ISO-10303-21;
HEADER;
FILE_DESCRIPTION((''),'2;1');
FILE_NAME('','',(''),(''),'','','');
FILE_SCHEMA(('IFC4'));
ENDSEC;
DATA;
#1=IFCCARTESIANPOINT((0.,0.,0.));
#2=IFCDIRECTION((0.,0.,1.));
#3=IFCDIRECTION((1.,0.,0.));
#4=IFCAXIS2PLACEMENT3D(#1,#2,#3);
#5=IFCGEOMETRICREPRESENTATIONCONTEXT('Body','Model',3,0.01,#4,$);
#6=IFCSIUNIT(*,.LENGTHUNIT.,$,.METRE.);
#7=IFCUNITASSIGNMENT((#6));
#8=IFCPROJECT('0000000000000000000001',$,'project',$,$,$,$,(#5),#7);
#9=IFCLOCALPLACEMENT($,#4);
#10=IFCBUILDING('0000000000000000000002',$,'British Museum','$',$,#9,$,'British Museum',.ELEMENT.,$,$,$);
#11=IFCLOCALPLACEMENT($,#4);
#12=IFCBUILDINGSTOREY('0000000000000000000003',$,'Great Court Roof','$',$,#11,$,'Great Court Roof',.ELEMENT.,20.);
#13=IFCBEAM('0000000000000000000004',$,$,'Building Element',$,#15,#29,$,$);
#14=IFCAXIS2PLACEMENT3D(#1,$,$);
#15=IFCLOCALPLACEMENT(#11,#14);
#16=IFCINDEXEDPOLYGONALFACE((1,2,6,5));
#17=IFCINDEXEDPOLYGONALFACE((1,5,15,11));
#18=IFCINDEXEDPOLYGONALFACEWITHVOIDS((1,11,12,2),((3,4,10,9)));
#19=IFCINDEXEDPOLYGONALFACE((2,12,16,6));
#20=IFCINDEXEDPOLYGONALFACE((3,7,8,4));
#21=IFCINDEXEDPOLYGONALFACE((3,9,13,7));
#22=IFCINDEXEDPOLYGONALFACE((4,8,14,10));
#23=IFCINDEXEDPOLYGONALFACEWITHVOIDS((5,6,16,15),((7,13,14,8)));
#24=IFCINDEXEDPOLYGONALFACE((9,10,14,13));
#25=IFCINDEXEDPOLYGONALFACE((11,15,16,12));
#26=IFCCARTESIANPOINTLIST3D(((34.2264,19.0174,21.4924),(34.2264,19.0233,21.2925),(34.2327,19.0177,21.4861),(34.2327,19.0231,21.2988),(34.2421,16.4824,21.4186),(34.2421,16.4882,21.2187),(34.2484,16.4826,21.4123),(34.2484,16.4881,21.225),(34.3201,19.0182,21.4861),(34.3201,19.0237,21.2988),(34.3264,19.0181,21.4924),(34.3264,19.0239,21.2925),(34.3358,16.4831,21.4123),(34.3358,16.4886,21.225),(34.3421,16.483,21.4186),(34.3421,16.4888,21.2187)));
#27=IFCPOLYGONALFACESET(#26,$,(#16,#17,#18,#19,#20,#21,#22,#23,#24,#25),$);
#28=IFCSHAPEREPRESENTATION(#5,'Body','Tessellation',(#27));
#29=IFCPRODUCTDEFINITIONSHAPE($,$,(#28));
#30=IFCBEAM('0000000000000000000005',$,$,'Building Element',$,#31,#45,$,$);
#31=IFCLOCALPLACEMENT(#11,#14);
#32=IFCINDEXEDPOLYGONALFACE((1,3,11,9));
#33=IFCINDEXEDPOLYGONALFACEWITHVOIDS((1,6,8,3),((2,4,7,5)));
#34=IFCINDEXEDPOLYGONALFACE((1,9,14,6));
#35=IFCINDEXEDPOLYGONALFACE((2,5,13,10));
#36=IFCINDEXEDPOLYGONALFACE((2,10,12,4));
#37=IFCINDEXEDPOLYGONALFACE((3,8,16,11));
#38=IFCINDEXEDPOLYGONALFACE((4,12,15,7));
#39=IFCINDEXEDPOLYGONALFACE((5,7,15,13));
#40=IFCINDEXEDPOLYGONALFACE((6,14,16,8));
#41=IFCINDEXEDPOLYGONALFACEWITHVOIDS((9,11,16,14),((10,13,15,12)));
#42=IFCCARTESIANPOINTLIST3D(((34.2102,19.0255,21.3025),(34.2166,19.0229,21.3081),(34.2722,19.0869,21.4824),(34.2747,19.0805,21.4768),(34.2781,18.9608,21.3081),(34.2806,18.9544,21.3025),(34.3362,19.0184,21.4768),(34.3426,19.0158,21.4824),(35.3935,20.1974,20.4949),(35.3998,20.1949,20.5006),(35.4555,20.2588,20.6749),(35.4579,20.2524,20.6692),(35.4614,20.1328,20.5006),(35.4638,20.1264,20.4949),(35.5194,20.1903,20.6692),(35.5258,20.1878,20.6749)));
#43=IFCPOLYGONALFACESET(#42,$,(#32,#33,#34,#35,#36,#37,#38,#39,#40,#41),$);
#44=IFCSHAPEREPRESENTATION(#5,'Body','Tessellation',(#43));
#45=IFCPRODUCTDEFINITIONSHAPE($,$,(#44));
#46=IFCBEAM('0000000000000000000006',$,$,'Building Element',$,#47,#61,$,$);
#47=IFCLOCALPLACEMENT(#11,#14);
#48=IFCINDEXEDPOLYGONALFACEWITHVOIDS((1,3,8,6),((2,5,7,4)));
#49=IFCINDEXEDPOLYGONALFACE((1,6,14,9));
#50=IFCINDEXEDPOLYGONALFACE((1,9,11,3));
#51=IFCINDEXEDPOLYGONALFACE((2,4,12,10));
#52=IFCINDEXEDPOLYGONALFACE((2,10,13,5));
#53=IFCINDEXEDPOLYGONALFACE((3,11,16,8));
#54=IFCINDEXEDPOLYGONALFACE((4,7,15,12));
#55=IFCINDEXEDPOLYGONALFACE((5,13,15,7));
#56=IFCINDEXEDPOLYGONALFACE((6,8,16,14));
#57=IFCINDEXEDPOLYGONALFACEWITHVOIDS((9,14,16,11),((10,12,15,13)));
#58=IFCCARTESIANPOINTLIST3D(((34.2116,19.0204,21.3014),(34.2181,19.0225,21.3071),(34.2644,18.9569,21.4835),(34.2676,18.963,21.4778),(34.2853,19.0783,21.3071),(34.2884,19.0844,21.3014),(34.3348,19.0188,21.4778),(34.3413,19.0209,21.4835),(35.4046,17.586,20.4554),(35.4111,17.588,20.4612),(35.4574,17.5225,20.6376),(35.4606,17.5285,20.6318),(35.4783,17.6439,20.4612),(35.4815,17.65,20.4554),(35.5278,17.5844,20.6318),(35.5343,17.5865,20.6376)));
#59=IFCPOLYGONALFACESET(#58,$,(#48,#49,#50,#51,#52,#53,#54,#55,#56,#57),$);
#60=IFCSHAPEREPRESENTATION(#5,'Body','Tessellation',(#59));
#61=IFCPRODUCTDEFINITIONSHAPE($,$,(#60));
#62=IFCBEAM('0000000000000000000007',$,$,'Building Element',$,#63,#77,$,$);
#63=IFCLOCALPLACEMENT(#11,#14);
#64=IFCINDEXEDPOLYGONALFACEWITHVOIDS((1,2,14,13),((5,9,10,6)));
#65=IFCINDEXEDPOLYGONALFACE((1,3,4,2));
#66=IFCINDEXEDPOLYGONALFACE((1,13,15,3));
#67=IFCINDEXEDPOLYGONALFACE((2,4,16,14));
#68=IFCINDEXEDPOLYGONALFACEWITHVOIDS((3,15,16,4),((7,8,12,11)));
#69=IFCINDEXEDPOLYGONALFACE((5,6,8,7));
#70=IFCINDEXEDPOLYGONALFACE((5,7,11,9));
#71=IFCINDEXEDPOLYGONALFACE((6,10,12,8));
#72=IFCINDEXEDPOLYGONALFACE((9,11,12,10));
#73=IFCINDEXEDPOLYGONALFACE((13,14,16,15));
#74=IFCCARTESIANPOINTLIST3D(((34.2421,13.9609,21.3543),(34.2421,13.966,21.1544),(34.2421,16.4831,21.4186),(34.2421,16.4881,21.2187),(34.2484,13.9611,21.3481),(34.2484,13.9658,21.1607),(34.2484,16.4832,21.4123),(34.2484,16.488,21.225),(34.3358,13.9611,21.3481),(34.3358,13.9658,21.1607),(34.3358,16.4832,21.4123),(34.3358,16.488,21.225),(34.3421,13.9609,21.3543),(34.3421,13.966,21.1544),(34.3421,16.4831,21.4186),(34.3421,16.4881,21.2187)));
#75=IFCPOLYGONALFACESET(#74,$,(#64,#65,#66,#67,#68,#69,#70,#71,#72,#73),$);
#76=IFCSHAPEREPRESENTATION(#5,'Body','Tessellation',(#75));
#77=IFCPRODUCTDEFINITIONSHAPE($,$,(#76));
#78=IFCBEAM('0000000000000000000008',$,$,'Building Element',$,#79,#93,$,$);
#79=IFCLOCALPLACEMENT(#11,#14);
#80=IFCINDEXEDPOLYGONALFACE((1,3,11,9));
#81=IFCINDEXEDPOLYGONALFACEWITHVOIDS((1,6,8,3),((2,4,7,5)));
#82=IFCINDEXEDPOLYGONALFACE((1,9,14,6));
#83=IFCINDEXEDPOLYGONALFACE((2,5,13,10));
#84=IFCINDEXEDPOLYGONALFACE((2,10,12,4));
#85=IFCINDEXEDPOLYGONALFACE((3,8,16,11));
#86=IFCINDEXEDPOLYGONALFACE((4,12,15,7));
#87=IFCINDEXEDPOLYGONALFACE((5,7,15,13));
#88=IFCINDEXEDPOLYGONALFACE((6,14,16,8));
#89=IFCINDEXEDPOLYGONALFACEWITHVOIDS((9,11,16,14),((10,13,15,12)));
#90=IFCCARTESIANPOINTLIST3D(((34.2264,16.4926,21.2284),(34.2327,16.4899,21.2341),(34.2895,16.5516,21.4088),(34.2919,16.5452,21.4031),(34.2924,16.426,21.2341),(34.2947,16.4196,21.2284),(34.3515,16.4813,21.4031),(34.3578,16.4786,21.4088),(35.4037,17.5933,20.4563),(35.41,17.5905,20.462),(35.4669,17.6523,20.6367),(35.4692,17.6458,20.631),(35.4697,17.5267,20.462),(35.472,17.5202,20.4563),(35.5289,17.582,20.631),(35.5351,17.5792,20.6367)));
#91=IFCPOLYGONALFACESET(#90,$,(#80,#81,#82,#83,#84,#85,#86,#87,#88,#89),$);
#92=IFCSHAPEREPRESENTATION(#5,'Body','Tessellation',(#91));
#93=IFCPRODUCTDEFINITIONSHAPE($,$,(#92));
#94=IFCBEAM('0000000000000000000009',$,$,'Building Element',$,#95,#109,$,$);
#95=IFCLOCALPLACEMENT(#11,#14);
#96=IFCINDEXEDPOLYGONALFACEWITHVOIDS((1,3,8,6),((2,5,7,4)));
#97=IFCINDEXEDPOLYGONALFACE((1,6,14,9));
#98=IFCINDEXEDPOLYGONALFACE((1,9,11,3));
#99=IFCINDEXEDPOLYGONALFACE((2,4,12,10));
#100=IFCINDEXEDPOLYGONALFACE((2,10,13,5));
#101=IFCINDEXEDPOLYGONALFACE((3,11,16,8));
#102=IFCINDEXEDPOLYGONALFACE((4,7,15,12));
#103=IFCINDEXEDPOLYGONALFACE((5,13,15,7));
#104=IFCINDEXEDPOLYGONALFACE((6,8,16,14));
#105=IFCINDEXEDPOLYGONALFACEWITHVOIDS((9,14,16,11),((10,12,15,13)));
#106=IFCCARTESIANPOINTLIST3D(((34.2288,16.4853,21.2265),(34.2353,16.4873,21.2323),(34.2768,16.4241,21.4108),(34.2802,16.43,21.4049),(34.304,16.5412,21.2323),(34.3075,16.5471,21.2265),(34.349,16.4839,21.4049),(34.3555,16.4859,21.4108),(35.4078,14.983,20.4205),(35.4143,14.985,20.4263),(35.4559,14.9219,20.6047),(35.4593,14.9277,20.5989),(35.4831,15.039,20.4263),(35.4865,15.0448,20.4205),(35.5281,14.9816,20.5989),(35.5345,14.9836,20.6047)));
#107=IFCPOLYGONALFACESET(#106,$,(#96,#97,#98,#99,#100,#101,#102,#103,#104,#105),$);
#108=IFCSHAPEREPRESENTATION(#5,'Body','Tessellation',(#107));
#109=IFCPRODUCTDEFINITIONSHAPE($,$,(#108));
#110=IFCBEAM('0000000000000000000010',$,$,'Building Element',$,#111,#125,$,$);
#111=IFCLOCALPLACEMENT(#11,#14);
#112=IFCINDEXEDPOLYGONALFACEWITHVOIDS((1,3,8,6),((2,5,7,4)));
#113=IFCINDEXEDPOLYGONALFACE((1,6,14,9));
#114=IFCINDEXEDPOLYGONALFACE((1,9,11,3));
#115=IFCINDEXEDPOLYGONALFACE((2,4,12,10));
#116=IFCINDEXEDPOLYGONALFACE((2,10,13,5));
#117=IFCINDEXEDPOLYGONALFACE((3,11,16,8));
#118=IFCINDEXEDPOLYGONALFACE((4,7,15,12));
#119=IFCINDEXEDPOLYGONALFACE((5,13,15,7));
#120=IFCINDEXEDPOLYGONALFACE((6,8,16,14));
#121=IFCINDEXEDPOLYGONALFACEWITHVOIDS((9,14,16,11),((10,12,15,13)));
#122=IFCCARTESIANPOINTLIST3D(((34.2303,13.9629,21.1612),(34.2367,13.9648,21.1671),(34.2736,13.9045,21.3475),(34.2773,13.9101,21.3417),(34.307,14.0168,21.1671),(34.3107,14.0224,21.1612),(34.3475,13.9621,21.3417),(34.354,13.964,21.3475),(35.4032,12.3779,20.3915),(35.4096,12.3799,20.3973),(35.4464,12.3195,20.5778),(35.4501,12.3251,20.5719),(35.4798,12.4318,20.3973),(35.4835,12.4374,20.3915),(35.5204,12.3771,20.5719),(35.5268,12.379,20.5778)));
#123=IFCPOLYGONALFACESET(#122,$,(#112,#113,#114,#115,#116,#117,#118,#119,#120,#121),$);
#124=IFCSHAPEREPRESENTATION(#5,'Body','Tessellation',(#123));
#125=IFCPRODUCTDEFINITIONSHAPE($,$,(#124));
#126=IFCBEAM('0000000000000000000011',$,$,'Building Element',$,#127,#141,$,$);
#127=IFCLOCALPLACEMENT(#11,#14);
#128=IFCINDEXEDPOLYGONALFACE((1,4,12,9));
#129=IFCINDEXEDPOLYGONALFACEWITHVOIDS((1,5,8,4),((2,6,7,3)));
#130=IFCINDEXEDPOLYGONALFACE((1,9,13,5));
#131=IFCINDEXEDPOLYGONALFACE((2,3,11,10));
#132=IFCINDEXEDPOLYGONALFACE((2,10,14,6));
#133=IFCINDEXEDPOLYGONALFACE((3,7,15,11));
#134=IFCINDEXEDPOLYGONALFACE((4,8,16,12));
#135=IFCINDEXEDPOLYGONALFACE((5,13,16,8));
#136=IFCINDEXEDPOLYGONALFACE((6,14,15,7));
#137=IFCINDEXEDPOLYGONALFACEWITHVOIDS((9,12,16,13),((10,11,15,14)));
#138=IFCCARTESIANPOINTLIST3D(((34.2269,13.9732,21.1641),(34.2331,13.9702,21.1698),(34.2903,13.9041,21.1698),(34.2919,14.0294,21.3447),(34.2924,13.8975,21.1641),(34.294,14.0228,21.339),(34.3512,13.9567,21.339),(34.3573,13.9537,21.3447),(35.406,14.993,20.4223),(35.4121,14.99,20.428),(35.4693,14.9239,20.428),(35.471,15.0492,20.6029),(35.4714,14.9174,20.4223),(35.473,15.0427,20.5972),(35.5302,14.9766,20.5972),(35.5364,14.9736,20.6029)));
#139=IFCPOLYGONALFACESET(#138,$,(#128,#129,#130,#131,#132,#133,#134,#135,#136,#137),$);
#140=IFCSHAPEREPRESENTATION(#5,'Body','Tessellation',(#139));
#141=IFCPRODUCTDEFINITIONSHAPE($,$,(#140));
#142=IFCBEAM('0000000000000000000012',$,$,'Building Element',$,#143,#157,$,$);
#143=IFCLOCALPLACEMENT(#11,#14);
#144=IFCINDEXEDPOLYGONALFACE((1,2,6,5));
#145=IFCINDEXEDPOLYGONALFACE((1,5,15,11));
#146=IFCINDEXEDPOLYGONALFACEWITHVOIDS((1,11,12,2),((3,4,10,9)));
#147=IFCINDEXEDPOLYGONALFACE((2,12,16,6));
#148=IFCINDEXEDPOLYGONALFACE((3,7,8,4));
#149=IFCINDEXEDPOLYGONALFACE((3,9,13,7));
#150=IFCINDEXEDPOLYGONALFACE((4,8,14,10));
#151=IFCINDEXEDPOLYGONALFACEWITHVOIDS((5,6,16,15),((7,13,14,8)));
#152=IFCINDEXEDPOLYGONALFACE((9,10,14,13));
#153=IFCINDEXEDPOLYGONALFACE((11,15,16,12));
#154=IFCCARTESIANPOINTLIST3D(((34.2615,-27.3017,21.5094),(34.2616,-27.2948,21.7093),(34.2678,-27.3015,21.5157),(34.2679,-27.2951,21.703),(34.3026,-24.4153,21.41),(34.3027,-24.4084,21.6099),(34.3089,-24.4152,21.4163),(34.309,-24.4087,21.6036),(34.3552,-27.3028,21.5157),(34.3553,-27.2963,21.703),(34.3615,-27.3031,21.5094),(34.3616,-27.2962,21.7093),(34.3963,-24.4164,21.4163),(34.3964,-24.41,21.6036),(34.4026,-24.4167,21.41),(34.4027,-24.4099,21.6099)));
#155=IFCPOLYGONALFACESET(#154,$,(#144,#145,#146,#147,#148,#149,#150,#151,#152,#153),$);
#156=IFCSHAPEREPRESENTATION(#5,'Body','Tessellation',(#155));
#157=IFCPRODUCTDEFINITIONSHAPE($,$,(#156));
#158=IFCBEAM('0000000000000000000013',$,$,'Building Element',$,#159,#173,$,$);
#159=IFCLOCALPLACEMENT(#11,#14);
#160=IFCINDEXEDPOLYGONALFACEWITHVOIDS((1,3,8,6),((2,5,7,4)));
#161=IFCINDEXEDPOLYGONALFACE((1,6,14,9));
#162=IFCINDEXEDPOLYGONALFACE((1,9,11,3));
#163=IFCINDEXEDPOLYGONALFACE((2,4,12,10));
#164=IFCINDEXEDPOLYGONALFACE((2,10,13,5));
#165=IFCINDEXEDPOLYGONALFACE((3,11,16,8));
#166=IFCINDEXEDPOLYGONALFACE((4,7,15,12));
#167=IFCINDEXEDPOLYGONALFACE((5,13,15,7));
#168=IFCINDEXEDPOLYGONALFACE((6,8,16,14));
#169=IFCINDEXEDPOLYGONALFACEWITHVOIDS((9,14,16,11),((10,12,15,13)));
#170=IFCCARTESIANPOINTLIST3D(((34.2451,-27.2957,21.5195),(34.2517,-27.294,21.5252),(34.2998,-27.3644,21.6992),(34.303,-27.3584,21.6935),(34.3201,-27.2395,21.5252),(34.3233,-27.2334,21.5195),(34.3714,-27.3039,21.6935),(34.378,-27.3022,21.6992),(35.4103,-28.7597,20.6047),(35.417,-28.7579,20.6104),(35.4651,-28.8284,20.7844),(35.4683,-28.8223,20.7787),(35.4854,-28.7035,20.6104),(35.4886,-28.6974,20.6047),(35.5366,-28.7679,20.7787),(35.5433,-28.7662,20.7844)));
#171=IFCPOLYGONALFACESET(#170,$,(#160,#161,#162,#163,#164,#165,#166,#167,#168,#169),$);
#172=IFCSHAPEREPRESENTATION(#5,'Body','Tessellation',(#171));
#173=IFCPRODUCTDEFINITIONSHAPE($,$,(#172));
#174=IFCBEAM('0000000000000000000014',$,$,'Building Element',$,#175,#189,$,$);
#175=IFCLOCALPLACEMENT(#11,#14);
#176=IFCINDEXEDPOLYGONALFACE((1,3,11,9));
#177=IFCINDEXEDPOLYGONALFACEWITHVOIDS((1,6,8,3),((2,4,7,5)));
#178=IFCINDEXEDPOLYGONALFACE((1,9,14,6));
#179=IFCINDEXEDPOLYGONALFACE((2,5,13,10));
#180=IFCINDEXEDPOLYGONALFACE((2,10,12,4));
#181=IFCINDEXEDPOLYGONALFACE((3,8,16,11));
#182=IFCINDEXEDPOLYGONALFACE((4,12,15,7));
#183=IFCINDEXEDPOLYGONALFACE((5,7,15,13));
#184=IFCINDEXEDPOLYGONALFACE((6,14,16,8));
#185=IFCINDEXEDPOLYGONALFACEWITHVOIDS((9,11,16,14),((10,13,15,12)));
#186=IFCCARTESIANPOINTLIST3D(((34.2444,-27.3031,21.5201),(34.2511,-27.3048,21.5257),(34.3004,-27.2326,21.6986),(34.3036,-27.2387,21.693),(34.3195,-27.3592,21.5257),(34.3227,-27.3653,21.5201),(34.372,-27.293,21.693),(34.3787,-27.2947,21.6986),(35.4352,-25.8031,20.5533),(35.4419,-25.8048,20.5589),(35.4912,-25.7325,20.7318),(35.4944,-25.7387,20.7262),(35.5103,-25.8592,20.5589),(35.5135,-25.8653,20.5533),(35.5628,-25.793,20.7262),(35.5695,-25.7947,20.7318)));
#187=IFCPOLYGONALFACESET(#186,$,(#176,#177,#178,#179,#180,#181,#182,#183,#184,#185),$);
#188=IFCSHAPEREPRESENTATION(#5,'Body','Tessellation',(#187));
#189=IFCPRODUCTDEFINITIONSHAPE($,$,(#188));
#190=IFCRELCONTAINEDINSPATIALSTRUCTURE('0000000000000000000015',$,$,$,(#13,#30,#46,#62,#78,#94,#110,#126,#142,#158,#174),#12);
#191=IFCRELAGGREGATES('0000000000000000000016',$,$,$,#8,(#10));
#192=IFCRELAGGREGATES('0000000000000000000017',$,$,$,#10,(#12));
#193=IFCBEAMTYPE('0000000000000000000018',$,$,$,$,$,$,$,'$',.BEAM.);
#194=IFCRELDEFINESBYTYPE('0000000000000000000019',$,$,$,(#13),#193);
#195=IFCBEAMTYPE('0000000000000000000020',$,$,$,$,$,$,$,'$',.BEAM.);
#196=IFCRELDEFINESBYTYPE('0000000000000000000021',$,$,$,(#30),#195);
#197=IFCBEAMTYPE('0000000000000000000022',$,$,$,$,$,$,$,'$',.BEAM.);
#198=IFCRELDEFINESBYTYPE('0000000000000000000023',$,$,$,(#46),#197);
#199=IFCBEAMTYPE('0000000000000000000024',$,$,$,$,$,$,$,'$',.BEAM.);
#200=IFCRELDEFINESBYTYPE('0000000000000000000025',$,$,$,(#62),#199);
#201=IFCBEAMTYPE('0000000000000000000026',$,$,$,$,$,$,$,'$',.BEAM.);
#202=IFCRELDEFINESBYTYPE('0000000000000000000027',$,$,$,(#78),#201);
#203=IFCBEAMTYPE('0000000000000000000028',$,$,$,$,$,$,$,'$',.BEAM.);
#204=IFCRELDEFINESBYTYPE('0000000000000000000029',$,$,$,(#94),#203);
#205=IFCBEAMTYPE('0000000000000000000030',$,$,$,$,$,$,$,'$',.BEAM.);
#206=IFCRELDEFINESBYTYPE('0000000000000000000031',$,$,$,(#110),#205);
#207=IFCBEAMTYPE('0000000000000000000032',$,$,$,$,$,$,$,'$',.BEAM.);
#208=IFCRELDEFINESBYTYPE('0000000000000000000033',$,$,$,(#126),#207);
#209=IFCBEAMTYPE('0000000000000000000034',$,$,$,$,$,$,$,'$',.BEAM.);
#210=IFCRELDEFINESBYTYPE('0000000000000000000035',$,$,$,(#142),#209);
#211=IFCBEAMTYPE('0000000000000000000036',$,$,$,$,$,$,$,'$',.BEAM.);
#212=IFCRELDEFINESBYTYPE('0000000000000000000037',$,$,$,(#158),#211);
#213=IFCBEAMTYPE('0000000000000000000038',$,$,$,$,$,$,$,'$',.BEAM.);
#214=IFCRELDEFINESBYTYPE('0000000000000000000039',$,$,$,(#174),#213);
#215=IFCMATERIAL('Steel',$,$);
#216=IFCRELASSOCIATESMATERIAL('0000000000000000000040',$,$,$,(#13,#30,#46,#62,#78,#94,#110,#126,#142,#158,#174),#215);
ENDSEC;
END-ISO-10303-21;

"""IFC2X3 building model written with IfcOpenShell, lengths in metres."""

from ifc_helpers import new_model, si_unit, frame, origin_with_axes, origin_2d, place, context, project, spatial, hollow_rectangle, extrude, material, type_object, element, save


model = new_model("IFC2X3")

# Units and contexts
model_context = context("Model", 3, precision=0.01, world=origin_with_axes(), identifier="Body")
ifc_project = project(units=[si_unit("LENGTHUNIT", "METRE")], contexts=[model_context])

# Building, storey
building_placement = place(None, origin_with_axes())
building = spatial("IfcBuilding", under=ifc_project, at=building_placement, Name="British Museum", Description="$", LongName="British Museum", CompositionType="ELEMENT")
storey_placement = place(None, origin_with_axes())
storey = spatial("IfcBuildingStorey", under=building, at=storey_placement, Name="Great Court Roof", Description="$", LongName="Great Court Roof", CompositionType="ELEMENT", Elevation=20.0)

# Beams
ifc_material = material(Name="Steel")
beam_type_1 = type_object("IfcBeamType", ElementType="$", PredefinedType="BEAM")
beam_1_placement = place(None, origin_with_axes())
element("IfcBeam", 1, at=beam_1_placement, inside=storey, type_object=beam_type_1, material=ifc_material, Description="Building Element", context=model_context, shape_type="SweptSolid", body=[
    extrude(hollow_rectangle(XDim=0.1, YDim=0.2, WallThickness=0.0063, InnerFilletRadius=0.0, OuterFilletRadius=0.0, at=origin_2d()), frame((34.2764, 19.0207, 21.3924), z_axis=(0.006196, -0.999557, -0.029107), x_axis=(0.999981, 0.006198, 0.0)), (0.0, 0.0, 1.0), 2.5362),
])
beam_type_2 = type_object("IfcBeamType", ElementType="$", PredefinedType="BEAM")
beam_2_placement = place(None, origin_with_axes())
element("IfcBeam", 2, at=beam_2_placement, inside=storey, type_object=beam_type_2, material=ifc_material, Description="Building Element", context=model_context, shape_type="SweptSolid", body=[
    extrude(hollow_rectangle(XDim=0.1, YDim=0.2, WallThickness=0.0063, InnerFilletRadius=0.0, OuterFilletRadius=0.0, at=origin_2d()), frame((34.2764, 19.0207, 21.3924), z_axis=(0.639296, 0.633198, -0.436304), x_axis=(-0.70371, 0.710487, 0.0)), (0.0, 0.0, 1.0), 1.8508),
])
beam_type_3 = type_object("IfcBeamType", ElementType="$", PredefinedType="BEAM")
beam_3_placement = place(None, origin_with_axes())
element("IfcBeam", 3, at=beam_3_placement, inside=storey, type_object=beam_type_3, material=ifc_material, Description="Building Element", context=model_context, shape_type="SweptSolid", body=[
    extrude(hollow_rectangle(XDim=0.1, YDim=0.2, WallThickness=0.0063, InnerFilletRadius=0.0, OuterFilletRadius=0.0, at=origin_2d()), frame((34.2764, 19.0207, 21.3924), z_axis=(0.582379, -0.700216, -0.412956), x_axis=(0.768833, 0.639449, 0.0)), (0.0, 0.0, 1.0), 2.0485),
])
beam_type_4 = type_object("IfcBeamType", ElementType="$", PredefinedType="BEAM")
beam_4_placement = place(None, origin_with_axes())
element("IfcBeam", 4, at=beam_4_placement, inside=storey, type_object=beam_type_4, material=ifc_material, Description="Building Element", context=model_context, shape_type="SweptSolid", body=[
    extrude(hollow_rectangle(XDim=0.1, YDim=0.2, WallThickness=0.0063, InnerFilletRadius=0.0, OuterFilletRadius=0.0, at=origin_2d()), frame((34.2921, 16.4856, 21.3186), z_axis=(0.000006, -0.999676, -0.025463), x_axis=(1.0, 0.000006, 0.0)), (0.0, 0.0, 1.0), 2.523),
])
beam_type_5 = type_object("IfcBeamType", ElementType="$", PredefinedType="BEAM")
beam_5_placement = place(None, origin_with_axes())
element("IfcBeam", 5, at=beam_5_placement, inside=storey, type_object=beam_type_5, material=ifc_material, Description="Building Element", context=model_context, shape_type="SweptSolid", body=[
    extrude(hollow_rectangle(XDim=0.1, YDim=0.2, WallThickness=0.0063, InnerFilletRadius=0.0, OuterFilletRadius=0.0, at=origin_2d()), frame((34.2921, 16.4856, 21.3186), z_axis=(0.658793, 0.615882, -0.432066), x_axis=(-0.682916, 0.730497, 0.0)), (0.0, 0.0, 1.0), 1.7871),
])
beam_type_6 = type_object("IfcBeamType", ElementType="$", PredefinedType="BEAM")
beam_6_placement = place(None, origin_with_axes())
element("IfcBeam", 6, at=beam_6_placement, inside=storey, type_object=beam_type_6, material=ifc_material, Description="Building Element", context=model_context, shape_type="SweptSolid", body=[
    extrude(hollow_rectangle(XDim=0.1, YDim=0.2, WallThickness=0.0063, InnerFilletRadius=0.0, OuterFilletRadius=0.0, at=origin_2d()), frame((34.2921, 16.4856, 21.3186), z_axis=(0.568809, -0.724741, -0.388852), x_axis=(0.786651, 0.617398, 0.0)), (0.0, 0.0, 1.0), 2.0729),
])
beam_type_7 = type_object("IfcBeamType", ElementType="$", PredefinedType="BEAM")
beam_7_placement = place(None, origin_with_axes())
element("IfcBeam", 7, at=beam_7_placement, inside=storey, type_object=beam_type_7, material=ifc_material, Description="Building Element", context=model_context, shape_type="SweptSolid", body=[
    extrude(hollow_rectangle(XDim=0.1, YDim=0.2, WallThickness=0.0063, InnerFilletRadius=0.0, OuterFilletRadius=0.0, at=origin_2d()), frame((34.2921, 13.9634, 21.2544), z_axis=(0.554097, -0.748813, -0.36367), x_axis=(0.803855, 0.594826, 0.0)), (0.0, 0.0, 1.0), 2.1167),
])
beam_type_8 = type_object("IfcBeamType", ElementType="$", PredefinedType="BEAM")
beam_8_placement = place(None, origin_with_axes())
element("IfcBeam", 8, at=beam_8_placement, inside=storey, type_object=beam_type_8, material=ifc_material, Description="Building Element", context=model_context, shape_type="SweptSolid", body=[
    extrude(hollow_rectangle(XDim=0.1, YDim=0.2, WallThickness=0.0063, InnerFilletRadius=0.0, OuterFilletRadius=0.0, at=origin_2d()), frame((34.2921, 13.9634, 21.2544), z_axis=(0.68294, 0.590743, -0.429669), x_axis=(-0.65421, 0.756313, 0.0)), (0.0, 0.0, 1.0), 1.7264),
])
beam_type_9 = type_object("IfcBeamType", ElementType="$", PredefinedType="BEAM")
beam_9_placement = place(None, origin_with_axes())
element("IfcBeam", 9, at=beam_9_placement, inside=storey, type_object=beam_type_9, material=ifc_material, Description="Building Element", context=model_context, shape_type="SweptSolid", body=[
    extrude(hollow_rectangle(XDim=0.1, YDim=0.2, WallThickness=0.0063, InnerFilletRadius=0.0, OuterFilletRadius=0.0, at=origin_2d()), frame((34.3115, -27.2989, 21.6094), z_axis=(0.014241, 0.999306, -0.03442), x_axis=(-0.999898, 0.01425, 0.0)), (0.0, 0.0, 1.0), 2.8884),
])
beam_type_10 = type_object("IfcBeamType", ElementType="$", PredefinedType="BEAM")
beam_10_placement = place(None, origin_with_axes())
element("IfcBeam", 10, at=beam_10_placement, inside=storey, type_object=beam_type_10, material=ifc_material, Description="Building Element", context=model_context, shape_type="SweptSolid", body=[
    extrude(hollow_rectangle(XDim=0.1, YDim=0.2, WallThickness=0.0063, InnerFilletRadius=0.0, OuterFilletRadius=0.0, at=origin_2d()), frame((34.3115, -27.2989, 21.6094), z_axis=(0.559474, -0.702897, -0.439233), x_axis=(0.78241, 0.622763, 0.0)), (0.0, 0.0, 1.0), 2.0828),
])
beam_type_11 = type_object("IfcBeamType", ElementType="$", PredefinedType="BEAM")
beam_11_placement = place(None, origin_with_axes())
element("IfcBeam", 11, at=beam_11_placement, inside=storey, type_object=beam_type_11, material=ifc_material, Description="Building Element", context=model_context, shape_type="SweptSolid", body=[
    extrude(hollow_rectangle(XDim=0.1, YDim=0.2, WallThickness=0.0063, InnerFilletRadius=0.0, OuterFilletRadius=0.0, at=origin_2d()), frame((34.3115, -27.2989, 21.6094), z_axis=(0.555046, 0.69917, -0.450649), x_axis=(-0.783207, 0.621761, 0.0)), (0.0, 0.0, 1.0), 2.1454),
])

save(model, "model.ifc")
